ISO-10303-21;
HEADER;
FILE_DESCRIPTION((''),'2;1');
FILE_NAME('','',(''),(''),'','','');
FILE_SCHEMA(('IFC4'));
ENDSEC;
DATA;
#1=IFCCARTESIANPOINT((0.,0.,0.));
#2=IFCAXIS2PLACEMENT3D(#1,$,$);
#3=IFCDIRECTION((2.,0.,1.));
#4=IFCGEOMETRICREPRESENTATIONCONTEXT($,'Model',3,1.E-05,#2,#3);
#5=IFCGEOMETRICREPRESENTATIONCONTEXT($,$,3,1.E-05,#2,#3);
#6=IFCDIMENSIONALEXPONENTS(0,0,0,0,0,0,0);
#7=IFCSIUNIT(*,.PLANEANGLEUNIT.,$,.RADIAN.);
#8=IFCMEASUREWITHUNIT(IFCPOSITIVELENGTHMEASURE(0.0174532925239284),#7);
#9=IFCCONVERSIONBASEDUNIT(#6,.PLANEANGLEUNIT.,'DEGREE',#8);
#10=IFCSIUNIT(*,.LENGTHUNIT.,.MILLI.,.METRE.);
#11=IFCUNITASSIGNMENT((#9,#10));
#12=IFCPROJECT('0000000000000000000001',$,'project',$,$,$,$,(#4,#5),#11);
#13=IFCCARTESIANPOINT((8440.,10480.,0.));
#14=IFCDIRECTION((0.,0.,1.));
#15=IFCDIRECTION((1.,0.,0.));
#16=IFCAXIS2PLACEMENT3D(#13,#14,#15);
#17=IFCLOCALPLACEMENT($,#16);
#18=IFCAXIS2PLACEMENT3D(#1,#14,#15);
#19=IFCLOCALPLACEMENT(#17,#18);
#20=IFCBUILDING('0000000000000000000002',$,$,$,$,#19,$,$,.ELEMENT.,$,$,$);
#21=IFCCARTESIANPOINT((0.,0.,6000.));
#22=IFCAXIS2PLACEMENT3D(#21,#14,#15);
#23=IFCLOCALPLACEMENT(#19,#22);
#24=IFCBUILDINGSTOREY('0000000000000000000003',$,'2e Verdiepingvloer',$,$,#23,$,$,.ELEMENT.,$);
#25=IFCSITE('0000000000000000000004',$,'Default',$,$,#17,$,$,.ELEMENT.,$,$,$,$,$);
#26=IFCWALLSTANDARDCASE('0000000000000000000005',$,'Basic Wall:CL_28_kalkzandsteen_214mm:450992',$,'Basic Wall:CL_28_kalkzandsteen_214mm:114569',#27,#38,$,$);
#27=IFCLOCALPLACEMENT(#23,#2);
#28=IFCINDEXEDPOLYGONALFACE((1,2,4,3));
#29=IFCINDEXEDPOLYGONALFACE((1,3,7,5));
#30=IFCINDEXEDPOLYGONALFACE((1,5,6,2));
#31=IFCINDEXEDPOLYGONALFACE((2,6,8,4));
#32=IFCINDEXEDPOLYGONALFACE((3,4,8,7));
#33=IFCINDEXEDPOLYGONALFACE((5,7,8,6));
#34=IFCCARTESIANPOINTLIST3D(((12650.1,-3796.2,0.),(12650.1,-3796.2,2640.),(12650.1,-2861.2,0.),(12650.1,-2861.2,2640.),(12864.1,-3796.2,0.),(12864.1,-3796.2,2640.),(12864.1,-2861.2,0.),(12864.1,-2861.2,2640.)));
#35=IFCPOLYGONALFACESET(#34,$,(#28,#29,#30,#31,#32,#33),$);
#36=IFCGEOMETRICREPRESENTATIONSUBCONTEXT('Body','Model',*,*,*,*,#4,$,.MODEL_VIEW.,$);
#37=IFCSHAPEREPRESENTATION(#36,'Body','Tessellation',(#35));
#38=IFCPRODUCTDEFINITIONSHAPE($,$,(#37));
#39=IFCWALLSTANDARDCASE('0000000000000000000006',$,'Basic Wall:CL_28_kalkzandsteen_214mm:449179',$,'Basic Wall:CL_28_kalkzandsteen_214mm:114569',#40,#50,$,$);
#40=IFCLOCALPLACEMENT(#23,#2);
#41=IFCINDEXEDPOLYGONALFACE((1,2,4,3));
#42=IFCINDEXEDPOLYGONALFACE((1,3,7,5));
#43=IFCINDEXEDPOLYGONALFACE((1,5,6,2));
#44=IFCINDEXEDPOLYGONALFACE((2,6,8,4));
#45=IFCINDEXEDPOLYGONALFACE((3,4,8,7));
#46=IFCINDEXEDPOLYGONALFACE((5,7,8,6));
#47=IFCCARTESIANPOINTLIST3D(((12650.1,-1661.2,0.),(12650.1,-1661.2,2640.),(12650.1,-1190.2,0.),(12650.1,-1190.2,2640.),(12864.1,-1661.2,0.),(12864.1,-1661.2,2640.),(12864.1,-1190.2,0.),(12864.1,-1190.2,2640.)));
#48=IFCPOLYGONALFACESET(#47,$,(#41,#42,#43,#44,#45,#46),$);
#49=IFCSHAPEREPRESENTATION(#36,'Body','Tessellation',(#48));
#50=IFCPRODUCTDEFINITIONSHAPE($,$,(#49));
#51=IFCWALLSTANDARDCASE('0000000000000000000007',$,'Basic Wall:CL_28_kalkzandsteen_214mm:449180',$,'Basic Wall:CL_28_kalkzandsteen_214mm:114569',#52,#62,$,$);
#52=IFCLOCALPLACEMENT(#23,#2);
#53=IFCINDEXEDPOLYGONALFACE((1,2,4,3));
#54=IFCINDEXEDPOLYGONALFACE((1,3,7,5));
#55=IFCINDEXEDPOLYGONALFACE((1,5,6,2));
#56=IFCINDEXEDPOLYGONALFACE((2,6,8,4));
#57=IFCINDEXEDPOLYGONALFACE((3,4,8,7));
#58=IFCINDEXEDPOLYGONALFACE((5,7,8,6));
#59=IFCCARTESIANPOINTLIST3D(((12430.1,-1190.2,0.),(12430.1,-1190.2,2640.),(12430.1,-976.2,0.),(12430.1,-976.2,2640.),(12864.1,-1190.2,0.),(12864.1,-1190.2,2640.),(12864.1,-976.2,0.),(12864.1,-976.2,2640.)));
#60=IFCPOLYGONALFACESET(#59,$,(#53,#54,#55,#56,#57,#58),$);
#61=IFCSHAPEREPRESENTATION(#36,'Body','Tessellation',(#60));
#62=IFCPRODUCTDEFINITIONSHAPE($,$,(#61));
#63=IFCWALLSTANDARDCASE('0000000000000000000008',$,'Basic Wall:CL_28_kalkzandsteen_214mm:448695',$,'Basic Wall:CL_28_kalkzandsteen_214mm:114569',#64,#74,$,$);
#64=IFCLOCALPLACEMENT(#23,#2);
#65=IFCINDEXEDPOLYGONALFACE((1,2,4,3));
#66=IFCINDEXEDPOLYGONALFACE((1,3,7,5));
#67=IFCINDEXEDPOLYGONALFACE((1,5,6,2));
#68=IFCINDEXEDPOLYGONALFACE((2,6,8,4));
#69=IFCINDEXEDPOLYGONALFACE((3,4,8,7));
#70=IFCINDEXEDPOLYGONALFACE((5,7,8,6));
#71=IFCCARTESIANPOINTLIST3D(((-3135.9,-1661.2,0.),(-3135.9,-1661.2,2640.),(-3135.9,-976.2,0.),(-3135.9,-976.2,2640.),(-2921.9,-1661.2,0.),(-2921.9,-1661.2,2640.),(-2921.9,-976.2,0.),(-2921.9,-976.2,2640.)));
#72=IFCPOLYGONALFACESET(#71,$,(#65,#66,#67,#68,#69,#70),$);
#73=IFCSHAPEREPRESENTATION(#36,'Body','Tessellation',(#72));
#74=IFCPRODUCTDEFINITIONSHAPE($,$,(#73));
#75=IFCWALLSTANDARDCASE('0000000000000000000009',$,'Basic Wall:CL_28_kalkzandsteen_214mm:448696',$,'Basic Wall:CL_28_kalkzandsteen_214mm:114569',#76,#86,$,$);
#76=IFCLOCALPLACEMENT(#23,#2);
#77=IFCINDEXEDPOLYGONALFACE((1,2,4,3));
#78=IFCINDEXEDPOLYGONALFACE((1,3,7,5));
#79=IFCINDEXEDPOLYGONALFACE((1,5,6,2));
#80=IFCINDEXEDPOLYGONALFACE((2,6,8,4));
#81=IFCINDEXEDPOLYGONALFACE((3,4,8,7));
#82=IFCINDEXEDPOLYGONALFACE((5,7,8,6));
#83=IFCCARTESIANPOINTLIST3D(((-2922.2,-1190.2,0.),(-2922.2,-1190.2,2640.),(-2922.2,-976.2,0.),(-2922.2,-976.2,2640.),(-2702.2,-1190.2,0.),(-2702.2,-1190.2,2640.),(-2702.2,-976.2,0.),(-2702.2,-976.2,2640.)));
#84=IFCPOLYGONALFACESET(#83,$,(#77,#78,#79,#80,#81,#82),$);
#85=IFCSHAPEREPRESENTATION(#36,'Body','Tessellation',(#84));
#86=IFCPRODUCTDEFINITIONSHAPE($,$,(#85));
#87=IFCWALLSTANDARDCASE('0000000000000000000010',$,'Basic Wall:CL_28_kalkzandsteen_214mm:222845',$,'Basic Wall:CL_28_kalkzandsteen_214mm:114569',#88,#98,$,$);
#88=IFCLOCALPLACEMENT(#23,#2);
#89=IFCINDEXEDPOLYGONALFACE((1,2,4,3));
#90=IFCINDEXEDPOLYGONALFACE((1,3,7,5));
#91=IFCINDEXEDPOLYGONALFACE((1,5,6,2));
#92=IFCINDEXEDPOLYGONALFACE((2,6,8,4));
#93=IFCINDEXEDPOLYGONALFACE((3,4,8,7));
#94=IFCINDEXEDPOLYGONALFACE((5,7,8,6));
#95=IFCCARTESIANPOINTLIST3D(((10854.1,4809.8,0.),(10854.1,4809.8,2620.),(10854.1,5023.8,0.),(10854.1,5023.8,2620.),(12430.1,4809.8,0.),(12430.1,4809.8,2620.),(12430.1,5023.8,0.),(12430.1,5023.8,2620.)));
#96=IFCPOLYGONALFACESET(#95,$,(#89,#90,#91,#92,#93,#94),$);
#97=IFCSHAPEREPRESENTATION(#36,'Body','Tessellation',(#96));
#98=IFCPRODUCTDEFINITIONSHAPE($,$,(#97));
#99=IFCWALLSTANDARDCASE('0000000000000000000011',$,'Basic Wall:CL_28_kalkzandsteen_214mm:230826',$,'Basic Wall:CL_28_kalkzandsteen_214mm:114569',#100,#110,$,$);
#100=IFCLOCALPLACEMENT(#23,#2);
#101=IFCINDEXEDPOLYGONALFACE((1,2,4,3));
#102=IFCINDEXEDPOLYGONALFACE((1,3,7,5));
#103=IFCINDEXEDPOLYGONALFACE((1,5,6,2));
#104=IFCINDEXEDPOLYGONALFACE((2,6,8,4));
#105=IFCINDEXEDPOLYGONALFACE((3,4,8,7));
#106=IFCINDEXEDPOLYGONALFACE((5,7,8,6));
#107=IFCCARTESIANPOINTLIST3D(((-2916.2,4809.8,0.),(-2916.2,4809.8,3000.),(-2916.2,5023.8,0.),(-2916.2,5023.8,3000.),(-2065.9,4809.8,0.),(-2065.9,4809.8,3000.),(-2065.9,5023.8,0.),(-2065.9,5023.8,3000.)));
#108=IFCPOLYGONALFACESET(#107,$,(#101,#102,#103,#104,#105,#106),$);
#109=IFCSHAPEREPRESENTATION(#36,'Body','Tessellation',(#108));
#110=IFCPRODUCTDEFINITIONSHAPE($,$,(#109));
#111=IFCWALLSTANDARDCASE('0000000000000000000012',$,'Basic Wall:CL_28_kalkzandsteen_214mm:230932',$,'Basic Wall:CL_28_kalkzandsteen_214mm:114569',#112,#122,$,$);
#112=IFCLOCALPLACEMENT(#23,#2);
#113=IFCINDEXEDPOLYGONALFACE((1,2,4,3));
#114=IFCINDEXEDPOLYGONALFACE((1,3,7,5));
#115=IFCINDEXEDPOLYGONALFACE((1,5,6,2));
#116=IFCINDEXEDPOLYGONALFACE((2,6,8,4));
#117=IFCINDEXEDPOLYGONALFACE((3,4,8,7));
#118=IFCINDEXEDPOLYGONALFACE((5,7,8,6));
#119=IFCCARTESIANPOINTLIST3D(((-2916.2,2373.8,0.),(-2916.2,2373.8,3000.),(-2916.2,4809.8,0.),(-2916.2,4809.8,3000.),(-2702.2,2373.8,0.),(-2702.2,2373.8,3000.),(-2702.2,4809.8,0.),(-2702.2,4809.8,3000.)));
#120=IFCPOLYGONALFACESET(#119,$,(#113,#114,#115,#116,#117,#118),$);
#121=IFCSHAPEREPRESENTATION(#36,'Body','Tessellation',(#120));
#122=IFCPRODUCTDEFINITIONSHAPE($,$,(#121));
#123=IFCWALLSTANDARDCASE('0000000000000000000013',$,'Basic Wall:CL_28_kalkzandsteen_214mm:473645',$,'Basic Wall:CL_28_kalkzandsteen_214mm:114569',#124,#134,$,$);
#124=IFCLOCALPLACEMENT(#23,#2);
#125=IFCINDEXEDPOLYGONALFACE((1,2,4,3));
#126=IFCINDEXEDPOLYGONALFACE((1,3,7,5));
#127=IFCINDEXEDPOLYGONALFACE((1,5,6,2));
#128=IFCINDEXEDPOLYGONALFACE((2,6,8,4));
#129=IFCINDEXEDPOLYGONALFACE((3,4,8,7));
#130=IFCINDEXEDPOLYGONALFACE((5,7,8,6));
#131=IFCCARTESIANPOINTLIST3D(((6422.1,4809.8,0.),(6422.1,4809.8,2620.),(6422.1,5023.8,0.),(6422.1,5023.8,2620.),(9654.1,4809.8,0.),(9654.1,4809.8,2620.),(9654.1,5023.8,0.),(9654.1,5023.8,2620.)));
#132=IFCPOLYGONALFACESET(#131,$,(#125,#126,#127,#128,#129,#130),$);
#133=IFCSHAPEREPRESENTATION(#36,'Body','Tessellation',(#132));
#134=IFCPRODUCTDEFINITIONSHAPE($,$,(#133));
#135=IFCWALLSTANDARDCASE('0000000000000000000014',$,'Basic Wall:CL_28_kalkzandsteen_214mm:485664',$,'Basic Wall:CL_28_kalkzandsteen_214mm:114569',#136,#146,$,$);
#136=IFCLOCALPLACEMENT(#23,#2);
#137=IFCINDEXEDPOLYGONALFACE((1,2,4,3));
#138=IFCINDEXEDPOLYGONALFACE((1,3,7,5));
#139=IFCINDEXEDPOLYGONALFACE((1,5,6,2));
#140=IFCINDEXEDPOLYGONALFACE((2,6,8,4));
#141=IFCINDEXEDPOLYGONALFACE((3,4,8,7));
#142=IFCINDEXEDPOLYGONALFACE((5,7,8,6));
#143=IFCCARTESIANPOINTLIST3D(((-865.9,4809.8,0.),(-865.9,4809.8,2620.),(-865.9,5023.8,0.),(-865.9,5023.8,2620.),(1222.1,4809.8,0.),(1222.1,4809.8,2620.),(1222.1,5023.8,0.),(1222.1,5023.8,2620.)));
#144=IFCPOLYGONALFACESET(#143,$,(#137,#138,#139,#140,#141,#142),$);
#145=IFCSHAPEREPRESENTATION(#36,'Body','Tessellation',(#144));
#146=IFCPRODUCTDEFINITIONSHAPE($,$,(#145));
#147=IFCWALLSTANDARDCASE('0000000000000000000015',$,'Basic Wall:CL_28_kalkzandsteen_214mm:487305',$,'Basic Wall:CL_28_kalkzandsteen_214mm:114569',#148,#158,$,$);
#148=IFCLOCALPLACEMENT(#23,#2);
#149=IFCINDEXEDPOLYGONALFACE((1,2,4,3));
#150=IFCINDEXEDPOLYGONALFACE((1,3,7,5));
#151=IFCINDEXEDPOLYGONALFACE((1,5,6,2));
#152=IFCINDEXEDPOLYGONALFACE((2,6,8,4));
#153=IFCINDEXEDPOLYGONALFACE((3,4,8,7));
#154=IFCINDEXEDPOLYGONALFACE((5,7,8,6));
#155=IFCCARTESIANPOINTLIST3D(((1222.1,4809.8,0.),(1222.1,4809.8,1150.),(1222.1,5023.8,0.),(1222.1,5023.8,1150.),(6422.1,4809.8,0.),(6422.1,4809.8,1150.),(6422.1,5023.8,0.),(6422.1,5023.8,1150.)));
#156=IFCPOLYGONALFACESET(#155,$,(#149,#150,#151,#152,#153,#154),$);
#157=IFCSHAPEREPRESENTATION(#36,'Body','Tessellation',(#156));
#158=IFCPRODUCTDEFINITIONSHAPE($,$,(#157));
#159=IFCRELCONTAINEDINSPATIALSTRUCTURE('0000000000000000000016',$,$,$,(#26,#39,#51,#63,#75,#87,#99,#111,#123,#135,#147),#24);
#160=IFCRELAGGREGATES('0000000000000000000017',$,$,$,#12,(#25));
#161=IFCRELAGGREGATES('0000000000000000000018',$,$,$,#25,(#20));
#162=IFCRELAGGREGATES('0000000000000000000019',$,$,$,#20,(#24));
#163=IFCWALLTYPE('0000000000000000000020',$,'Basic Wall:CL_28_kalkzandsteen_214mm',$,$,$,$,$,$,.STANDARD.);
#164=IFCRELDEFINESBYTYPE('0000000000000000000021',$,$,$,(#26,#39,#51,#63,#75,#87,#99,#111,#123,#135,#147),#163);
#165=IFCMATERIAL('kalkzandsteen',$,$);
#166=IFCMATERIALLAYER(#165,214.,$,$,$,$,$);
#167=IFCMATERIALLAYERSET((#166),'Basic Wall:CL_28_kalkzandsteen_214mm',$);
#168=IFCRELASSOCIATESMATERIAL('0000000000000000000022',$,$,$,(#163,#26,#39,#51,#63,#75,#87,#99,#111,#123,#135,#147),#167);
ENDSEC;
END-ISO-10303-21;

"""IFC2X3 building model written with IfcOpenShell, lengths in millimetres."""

from ifc_helpers import new_model, entity, si_unit, converted_unit, direction, frame, frame_2d, origin, origin_with_axes, place, context, subcontext, project, spatial, polyline, rectangle, extrude, clip, bounded_halfspace, source, transform, mapped, material, layer, layer_set, layer_usage, type_object, element, save


model = new_model("IFC2X3")

# Units and contexts
model_context = context("Model", 3, precision=1e-05, world=origin(), true_north=direction((2.0, 0.0, 1.0)))
context_of_model = context(None, 3, precision=1e-05, world=origin(), true_north=direction((2.0, 0.0, 1.0)))
body_context = subcontext(model_context, "Body", "Model", "MODEL_VIEW")
ifc_project = project(units=[converted_unit("PLANEANGLEUNIT", "DEGREE", entity("IfcPositiveLengthMeasure", 0.0174532925239284), si_unit("PLANEANGLEUNIT", "RADIAN"), dimensions=[0, 0, 0, 0, 0, 0, 0]), si_unit("LENGTHUNIT", "METRE", prefix="MILLI")], contexts=[model_context, context_of_model])

# Site, building, storey
site_placement = place(None, frame((8440.0, 10480.0, 0.0), z_axis=(0.0, 0.0, 1.0), x_axis=(1.0, 0.0, 0.0)))
site = spatial("IfcSite", under=ifc_project, at=site_placement, Name="Default", CompositionType="ELEMENT")
building_placement = place(site_placement, origin_with_axes())
building = spatial("IfcBuilding", under=site, at=building_placement, CompositionType="ELEMENT")
storey_placement = place(building_placement, frame((0.0, 0.0, 6000.0), z_axis=(0.0, 0.0, 1.0), x_axis=(1.0, 0.0, 0.0)))
storey = spatial("IfcBuildingStorey", under=building, at=storey_placement, Name="2e Verdiepingvloer", CompositionType="ELEMENT")

# Walls
ifc_material_1 = material(Name="kalkzandsteen")
ifc_layer_1 = layer(ifc_material_1, 214.0)
ifc_layer_set_1 = layer_set([ifc_layer_1], Name="Basic Wall:CL_28_kalkzandsteen_214mm")
wall_type_1 = type_object("IfcWallType", Name="Basic Wall:CL_28_kalkzandsteen_214mm", PredefinedType="STANDARD", material=ifc_layer_set_1)
shared_shape_1 = source(origin(), body_context, "Body", "SweptSolid", [
    extrude(rectangle(XDim=935.0, YDim=214.0, at=frame_2d((467.5, 0.0), x_axis=(-1.0, 0.0))), origin(), (0.0, 0.0, 1.0), 2640.0),
])
ifc_layer_usage_1 = layer_usage(ifc_layer_set_1, "AXIS2", "NEGATIVE", 107.0)
wall_1_placement = place(storey_placement, frame((12757.1, -3796.2, 0.0), z_axis=(0.0, 0.0, 1.0), x_axis=(0.0, 1.0, 0.0)))
element("IfcWallStandardCase", 1, at=wall_1_placement, inside=storey, type_object=wall_type_1, material=ifc_layer_usage_1, Name="Basic Wall:CL_28_kalkzandsteen_214mm:450992", ObjectType="Basic Wall:CL_28_kalkzandsteen_214mm:114569", context=body_context, shape_type="MappedRepresentation", body=[
    mapped(shared_shape_1, transform((0.0, 0.0, 0.0))),
])
ifc_layer_usage_2 = layer_usage(ifc_layer_set_1, "AXIS2", "NEGATIVE", 107.0)
shared_shape_2 = source(origin(), body_context, "Body", "SweptSolid", [
    extrude(rectangle(XDim=471.0, YDim=214.0, at=frame_2d((235.5, 0.0), x_axis=(-1.0, 0.0))), origin(), (0.0, 0.0, 1.0), 2640.0),
])
wall_2_placement = place(storey_placement, frame((12757.1, -1661.2, 0.0), z_axis=(0.0, 0.0, 1.0), x_axis=(0.0, 1.0, 0.0)))
element("IfcWallStandardCase", 2, at=wall_2_placement, inside=storey, type_object=wall_type_1, material=ifc_layer_usage_2, Name="Basic Wall:CL_28_kalkzandsteen_214mm:449179", ObjectType="Basic Wall:CL_28_kalkzandsteen_214mm:114569", context=body_context, shape_type="MappedRepresentation", body=[
    mapped(shared_shape_2, transform((0.0, 0.0, 0.0))),
])
ifc_layer_usage_3 = layer_usage(ifc_layer_set_1, "AXIS2", "NEGATIVE", 107.0)
shared_shape_3 = source(origin(), body_context, "Body", "SweptSolid", [
    extrude(rectangle(XDim=434.0, YDim=214.0, at=frame_2d((217.0, 0.0), x_axis=(-1.0, 0.0))), origin(), (0.0, 0.0, 1.0), 2640.0),
])
wall_3_placement = place(storey_placement, frame((12864.1, -1083.2, 0.0), z_axis=(0.0, 0.0, 1.0), x_axis=(-1.0, 0.0, 0.0)))
element("IfcWallStandardCase", 3, at=wall_3_placement, inside=storey, type_object=wall_type_1, material=ifc_layer_usage_3, Name="Basic Wall:CL_28_kalkzandsteen_214mm:449180", ObjectType="Basic Wall:CL_28_kalkzandsteen_214mm:114569", context=body_context, shape_type="MappedRepresentation", body=[
    mapped(shared_shape_3, transform((0.0, 0.0, 0.0))),
])
ifc_layer_usage_4 = layer_usage(ifc_layer_set_1, "AXIS2", "NEGATIVE", 107.0)
shared_shape_4 = source(origin(), body_context, "Body", "SweptSolid", [
    extrude(rectangle(XDim=685.0, YDim=214.0, at=frame_2d((342.5, 0.0), x_axis=(-1.0, 0.0))), origin(), (0.0, 0.0, 1.0), 2640.0),
])
wall_4_placement = place(storey_placement, frame((-3028.9, -976.2, 0.0), z_axis=(0.0, 0.0, 1.0), x_axis=(0.0, -1.0, 0.0)))
element("IfcWallStandardCase", 4, at=wall_4_placement, inside=storey, type_object=wall_type_1, material=ifc_layer_usage_4, Name="Basic Wall:CL_28_kalkzandsteen_214mm:448695", ObjectType="Basic Wall:CL_28_kalkzandsteen_214mm:114569", context=body_context, shape_type="MappedRepresentation", body=[
    mapped(shared_shape_4, transform((0.0, 0.0, 0.0))),
])
ifc_layer_usage_5 = layer_usage(ifc_layer_set_1, "AXIS2", "NEGATIVE", 107.0)
shared_shape_5 = source(origin(), body_context, "Body", "SweptSolid", [
    extrude(rectangle(XDim=220.0, YDim=214.0, at=frame_2d((110.0, 0.0), x_axis=(-1.0, 0.0))), origin(), (0.0, 0.0, 1.0), 2640.0),
])
wall_5_placement = place(storey_placement, frame((-2702.2, -1083.2, 0.0), z_axis=(0.0, 0.0, 1.0), x_axis=(-1.0, 0.0, 0.0)))
element("IfcWallStandardCase", 5, at=wall_5_placement, inside=storey, type_object=wall_type_1, material=ifc_layer_usage_5, Name="Basic Wall:CL_28_kalkzandsteen_214mm:448696", ObjectType="Basic Wall:CL_28_kalkzandsteen_214mm:114569", context=body_context, shape_type="MappedRepresentation", body=[
    mapped(shared_shape_5, transform((0.0, 0.0, 0.0))),
])
ifc_layer_usage_6 = layer_usage(ifc_layer_set_1, "AXIS2", "NEGATIVE", 107.0)
wall_6_placement = place(storey_placement, frame((12430.1, 4916.8, 0.0), z_axis=(0.0, 0.0, 1.0), x_axis=(-1.0, 0.0, 0.0)))
element("IfcWallStandardCase", 6, at=wall_6_placement, inside=storey, type_object=wall_type_1, material=ifc_layer_usage_6, Name="Basic Wall:CL_28_kalkzandsteen_214mm:222845", ObjectType="Basic Wall:CL_28_kalkzandsteen_214mm:114569", context=body_context, shape_type="Clipping", body=[
    clip(extrude(rectangle(XDim=1576.0, YDim=214.0, at=frame_2d((788.0, 0.0), x_axis=(-1.0, 0.0))), origin(), (0.0, 0.0, 1.0), 2620.0), bounded_halfspace(frame((0.0, -107.0, 2620.0), z_axis=(0.0, 0.0, -1.0), x_axis=(-1.0, 0.0, 0.0)), True, frame((0.0, -107.0, 2620.0)), polyline([(0.0, 0.0), (1576.0, 0.0), (1576.0, 214.0), (0.0, 214.0), (0.0, 0.0)]))),
])
ifc_layer_usage_7 = layer_usage(ifc_layer_set_1, "AXIS2", "NEGATIVE", 107.0)
wall_7_placement = place(storey_placement, frame((-2065.9, 4916.8, 0.0), z_axis=(0.0, 0.0, 1.0), x_axis=(-1.0, 0.0, 0.0)))
element("IfcWallStandardCase", 7, at=wall_7_placement, inside=storey, type_object=wall_type_1, material=ifc_layer_usage_7, Name="Basic Wall:CL_28_kalkzandsteen_214mm:230826", ObjectType="Basic Wall:CL_28_kalkzandsteen_214mm:114569", context=body_context, shape_type="SweptSolid", body=[
    extrude(rectangle(XDim=850.3, YDim=214.0, at=frame_2d((425.1, 0.0), x_axis=(-1.0, 0.0))), origin(), (0.0, 0.0, 1.0), 3000.0),
])
ifc_layer_usage_8 = layer_usage(ifc_layer_set_1, "AXIS2", "NEGATIVE", 107.0)
wall_8_placement = place(storey_placement, frame((-2809.2, 4809.8, 0.0), z_axis=(0.0, 0.0, 1.0), x_axis=(0.0, -1.0, 0.0)))
element("IfcWallStandardCase", 8, at=wall_8_placement, inside=storey, type_object=wall_type_1, material=ifc_layer_usage_8, Name="Basic Wall:CL_28_kalkzandsteen_214mm:230932", ObjectType="Basic Wall:CL_28_kalkzandsteen_214mm:114569", context=body_context, shape_type="SweptSolid", body=[
    extrude(rectangle(XDim=2436.0, YDim=214.0, at=frame_2d((1218.0, 0.0), x_axis=(-1.0, 0.0))), origin(), (0.0, 0.0, 1.0), 3000.0),
])
ifc_layer_usage_9 = layer_usage(ifc_layer_set_1, "AXIS2", "NEGATIVE", 107.0)
wall_9_placement = place(storey_placement, frame((9654.1, 4916.8, 0.0), z_axis=(0.0, 0.0, 1.0), x_axis=(-1.0, 0.0, 0.0)))
element("IfcWallStandardCase", 9, at=wall_9_placement, inside=storey, type_object=wall_type_1, material=ifc_layer_usage_9, Name="Basic Wall:CL_28_kalkzandsteen_214mm:473645", ObjectType="Basic Wall:CL_28_kalkzandsteen_214mm:114569", context=body_context, shape_type="Clipping", body=[
    clip(extrude(rectangle(XDim=3232.0, YDim=214.0, at=frame_2d((1616.0, 0.0), x_axis=(-1.0, 0.0))), origin(), (0.0, 0.0, 1.0), 2620.0), bounded_halfspace(frame((0.0, -107.0, 2620.0), z_axis=(0.0, 0.0, -1.0), x_axis=(-1.0, 0.0, 0.0)), True, frame((0.0, -107.0, 2620.0)), polyline([(0.0, 0.0), (3232.0, 0.0), (3232.0, 214.0), (0.0, 214.0), (0.0, 0.0)]))),
])
ifc_layer_usage_10 = layer_usage(ifc_layer_set_1, "AXIS2", "NEGATIVE", 107.0)
wall_10_placement = place(storey_placement, frame((1222.1, 4916.8, 0.0), z_axis=(0.0, 0.0, 1.0), x_axis=(-1.0, 0.0, 0.0)))
element("IfcWallStandardCase", 10, at=wall_10_placement, inside=storey, type_object=wall_type_1, material=ifc_layer_usage_10, Name="Basic Wall:CL_28_kalkzandsteen_214mm:485664", ObjectType="Basic Wall:CL_28_kalkzandsteen_214mm:114569", context=body_context, shape_type="Clipping", body=[
    clip(extrude(rectangle(XDim=2088.0, YDim=214.0, at=frame_2d((1044.0, 0.0), x_axis=(-1.0, 0.0))), origin(), (0.0, 0.0, 1.0), 2620.0), bounded_halfspace(frame((0.0, -107.0, 2620.0), z_axis=(0.0, 0.0, -1.0), x_axis=(-1.0, 0.0, 0.0)), True, frame((0.0, -107.0, 2620.0)), polyline([(0.0, 0.0), (2088.0, 0.0), (2088.0, 214.0), (1144.0, 214.0), (0.0, 214.0), (0.0, 0.0)]))),
])
ifc_layer_usage_11 = layer_usage(ifc_layer_set_1, "AXIS2", "NEGATIVE", 107.0)
wall_11_placement = place(storey_placement, frame((6422.1, 4916.8, 0.0), z_axis=(0.0, 0.0, 1.0), x_axis=(-1.0, 0.0, 0.0)))
element("IfcWallStandardCase", 11, at=wall_11_placement, inside=storey, type_object=wall_type_1, material=ifc_layer_usage_11, Name="Basic Wall:CL_28_kalkzandsteen_214mm:487305", ObjectType="Basic Wall:CL_28_kalkzandsteen_214mm:114569", context=body_context, shape_type="SweptSolid", body=[
    extrude(rectangle(XDim=5200.0, YDim=214.0, at=frame_2d((2600.0, 0.0), x_axis=(-1.0, 0.0))), origin(), (0.0, 0.0, 1.0), 1150.0),
])

save(model, "model.ifc")
